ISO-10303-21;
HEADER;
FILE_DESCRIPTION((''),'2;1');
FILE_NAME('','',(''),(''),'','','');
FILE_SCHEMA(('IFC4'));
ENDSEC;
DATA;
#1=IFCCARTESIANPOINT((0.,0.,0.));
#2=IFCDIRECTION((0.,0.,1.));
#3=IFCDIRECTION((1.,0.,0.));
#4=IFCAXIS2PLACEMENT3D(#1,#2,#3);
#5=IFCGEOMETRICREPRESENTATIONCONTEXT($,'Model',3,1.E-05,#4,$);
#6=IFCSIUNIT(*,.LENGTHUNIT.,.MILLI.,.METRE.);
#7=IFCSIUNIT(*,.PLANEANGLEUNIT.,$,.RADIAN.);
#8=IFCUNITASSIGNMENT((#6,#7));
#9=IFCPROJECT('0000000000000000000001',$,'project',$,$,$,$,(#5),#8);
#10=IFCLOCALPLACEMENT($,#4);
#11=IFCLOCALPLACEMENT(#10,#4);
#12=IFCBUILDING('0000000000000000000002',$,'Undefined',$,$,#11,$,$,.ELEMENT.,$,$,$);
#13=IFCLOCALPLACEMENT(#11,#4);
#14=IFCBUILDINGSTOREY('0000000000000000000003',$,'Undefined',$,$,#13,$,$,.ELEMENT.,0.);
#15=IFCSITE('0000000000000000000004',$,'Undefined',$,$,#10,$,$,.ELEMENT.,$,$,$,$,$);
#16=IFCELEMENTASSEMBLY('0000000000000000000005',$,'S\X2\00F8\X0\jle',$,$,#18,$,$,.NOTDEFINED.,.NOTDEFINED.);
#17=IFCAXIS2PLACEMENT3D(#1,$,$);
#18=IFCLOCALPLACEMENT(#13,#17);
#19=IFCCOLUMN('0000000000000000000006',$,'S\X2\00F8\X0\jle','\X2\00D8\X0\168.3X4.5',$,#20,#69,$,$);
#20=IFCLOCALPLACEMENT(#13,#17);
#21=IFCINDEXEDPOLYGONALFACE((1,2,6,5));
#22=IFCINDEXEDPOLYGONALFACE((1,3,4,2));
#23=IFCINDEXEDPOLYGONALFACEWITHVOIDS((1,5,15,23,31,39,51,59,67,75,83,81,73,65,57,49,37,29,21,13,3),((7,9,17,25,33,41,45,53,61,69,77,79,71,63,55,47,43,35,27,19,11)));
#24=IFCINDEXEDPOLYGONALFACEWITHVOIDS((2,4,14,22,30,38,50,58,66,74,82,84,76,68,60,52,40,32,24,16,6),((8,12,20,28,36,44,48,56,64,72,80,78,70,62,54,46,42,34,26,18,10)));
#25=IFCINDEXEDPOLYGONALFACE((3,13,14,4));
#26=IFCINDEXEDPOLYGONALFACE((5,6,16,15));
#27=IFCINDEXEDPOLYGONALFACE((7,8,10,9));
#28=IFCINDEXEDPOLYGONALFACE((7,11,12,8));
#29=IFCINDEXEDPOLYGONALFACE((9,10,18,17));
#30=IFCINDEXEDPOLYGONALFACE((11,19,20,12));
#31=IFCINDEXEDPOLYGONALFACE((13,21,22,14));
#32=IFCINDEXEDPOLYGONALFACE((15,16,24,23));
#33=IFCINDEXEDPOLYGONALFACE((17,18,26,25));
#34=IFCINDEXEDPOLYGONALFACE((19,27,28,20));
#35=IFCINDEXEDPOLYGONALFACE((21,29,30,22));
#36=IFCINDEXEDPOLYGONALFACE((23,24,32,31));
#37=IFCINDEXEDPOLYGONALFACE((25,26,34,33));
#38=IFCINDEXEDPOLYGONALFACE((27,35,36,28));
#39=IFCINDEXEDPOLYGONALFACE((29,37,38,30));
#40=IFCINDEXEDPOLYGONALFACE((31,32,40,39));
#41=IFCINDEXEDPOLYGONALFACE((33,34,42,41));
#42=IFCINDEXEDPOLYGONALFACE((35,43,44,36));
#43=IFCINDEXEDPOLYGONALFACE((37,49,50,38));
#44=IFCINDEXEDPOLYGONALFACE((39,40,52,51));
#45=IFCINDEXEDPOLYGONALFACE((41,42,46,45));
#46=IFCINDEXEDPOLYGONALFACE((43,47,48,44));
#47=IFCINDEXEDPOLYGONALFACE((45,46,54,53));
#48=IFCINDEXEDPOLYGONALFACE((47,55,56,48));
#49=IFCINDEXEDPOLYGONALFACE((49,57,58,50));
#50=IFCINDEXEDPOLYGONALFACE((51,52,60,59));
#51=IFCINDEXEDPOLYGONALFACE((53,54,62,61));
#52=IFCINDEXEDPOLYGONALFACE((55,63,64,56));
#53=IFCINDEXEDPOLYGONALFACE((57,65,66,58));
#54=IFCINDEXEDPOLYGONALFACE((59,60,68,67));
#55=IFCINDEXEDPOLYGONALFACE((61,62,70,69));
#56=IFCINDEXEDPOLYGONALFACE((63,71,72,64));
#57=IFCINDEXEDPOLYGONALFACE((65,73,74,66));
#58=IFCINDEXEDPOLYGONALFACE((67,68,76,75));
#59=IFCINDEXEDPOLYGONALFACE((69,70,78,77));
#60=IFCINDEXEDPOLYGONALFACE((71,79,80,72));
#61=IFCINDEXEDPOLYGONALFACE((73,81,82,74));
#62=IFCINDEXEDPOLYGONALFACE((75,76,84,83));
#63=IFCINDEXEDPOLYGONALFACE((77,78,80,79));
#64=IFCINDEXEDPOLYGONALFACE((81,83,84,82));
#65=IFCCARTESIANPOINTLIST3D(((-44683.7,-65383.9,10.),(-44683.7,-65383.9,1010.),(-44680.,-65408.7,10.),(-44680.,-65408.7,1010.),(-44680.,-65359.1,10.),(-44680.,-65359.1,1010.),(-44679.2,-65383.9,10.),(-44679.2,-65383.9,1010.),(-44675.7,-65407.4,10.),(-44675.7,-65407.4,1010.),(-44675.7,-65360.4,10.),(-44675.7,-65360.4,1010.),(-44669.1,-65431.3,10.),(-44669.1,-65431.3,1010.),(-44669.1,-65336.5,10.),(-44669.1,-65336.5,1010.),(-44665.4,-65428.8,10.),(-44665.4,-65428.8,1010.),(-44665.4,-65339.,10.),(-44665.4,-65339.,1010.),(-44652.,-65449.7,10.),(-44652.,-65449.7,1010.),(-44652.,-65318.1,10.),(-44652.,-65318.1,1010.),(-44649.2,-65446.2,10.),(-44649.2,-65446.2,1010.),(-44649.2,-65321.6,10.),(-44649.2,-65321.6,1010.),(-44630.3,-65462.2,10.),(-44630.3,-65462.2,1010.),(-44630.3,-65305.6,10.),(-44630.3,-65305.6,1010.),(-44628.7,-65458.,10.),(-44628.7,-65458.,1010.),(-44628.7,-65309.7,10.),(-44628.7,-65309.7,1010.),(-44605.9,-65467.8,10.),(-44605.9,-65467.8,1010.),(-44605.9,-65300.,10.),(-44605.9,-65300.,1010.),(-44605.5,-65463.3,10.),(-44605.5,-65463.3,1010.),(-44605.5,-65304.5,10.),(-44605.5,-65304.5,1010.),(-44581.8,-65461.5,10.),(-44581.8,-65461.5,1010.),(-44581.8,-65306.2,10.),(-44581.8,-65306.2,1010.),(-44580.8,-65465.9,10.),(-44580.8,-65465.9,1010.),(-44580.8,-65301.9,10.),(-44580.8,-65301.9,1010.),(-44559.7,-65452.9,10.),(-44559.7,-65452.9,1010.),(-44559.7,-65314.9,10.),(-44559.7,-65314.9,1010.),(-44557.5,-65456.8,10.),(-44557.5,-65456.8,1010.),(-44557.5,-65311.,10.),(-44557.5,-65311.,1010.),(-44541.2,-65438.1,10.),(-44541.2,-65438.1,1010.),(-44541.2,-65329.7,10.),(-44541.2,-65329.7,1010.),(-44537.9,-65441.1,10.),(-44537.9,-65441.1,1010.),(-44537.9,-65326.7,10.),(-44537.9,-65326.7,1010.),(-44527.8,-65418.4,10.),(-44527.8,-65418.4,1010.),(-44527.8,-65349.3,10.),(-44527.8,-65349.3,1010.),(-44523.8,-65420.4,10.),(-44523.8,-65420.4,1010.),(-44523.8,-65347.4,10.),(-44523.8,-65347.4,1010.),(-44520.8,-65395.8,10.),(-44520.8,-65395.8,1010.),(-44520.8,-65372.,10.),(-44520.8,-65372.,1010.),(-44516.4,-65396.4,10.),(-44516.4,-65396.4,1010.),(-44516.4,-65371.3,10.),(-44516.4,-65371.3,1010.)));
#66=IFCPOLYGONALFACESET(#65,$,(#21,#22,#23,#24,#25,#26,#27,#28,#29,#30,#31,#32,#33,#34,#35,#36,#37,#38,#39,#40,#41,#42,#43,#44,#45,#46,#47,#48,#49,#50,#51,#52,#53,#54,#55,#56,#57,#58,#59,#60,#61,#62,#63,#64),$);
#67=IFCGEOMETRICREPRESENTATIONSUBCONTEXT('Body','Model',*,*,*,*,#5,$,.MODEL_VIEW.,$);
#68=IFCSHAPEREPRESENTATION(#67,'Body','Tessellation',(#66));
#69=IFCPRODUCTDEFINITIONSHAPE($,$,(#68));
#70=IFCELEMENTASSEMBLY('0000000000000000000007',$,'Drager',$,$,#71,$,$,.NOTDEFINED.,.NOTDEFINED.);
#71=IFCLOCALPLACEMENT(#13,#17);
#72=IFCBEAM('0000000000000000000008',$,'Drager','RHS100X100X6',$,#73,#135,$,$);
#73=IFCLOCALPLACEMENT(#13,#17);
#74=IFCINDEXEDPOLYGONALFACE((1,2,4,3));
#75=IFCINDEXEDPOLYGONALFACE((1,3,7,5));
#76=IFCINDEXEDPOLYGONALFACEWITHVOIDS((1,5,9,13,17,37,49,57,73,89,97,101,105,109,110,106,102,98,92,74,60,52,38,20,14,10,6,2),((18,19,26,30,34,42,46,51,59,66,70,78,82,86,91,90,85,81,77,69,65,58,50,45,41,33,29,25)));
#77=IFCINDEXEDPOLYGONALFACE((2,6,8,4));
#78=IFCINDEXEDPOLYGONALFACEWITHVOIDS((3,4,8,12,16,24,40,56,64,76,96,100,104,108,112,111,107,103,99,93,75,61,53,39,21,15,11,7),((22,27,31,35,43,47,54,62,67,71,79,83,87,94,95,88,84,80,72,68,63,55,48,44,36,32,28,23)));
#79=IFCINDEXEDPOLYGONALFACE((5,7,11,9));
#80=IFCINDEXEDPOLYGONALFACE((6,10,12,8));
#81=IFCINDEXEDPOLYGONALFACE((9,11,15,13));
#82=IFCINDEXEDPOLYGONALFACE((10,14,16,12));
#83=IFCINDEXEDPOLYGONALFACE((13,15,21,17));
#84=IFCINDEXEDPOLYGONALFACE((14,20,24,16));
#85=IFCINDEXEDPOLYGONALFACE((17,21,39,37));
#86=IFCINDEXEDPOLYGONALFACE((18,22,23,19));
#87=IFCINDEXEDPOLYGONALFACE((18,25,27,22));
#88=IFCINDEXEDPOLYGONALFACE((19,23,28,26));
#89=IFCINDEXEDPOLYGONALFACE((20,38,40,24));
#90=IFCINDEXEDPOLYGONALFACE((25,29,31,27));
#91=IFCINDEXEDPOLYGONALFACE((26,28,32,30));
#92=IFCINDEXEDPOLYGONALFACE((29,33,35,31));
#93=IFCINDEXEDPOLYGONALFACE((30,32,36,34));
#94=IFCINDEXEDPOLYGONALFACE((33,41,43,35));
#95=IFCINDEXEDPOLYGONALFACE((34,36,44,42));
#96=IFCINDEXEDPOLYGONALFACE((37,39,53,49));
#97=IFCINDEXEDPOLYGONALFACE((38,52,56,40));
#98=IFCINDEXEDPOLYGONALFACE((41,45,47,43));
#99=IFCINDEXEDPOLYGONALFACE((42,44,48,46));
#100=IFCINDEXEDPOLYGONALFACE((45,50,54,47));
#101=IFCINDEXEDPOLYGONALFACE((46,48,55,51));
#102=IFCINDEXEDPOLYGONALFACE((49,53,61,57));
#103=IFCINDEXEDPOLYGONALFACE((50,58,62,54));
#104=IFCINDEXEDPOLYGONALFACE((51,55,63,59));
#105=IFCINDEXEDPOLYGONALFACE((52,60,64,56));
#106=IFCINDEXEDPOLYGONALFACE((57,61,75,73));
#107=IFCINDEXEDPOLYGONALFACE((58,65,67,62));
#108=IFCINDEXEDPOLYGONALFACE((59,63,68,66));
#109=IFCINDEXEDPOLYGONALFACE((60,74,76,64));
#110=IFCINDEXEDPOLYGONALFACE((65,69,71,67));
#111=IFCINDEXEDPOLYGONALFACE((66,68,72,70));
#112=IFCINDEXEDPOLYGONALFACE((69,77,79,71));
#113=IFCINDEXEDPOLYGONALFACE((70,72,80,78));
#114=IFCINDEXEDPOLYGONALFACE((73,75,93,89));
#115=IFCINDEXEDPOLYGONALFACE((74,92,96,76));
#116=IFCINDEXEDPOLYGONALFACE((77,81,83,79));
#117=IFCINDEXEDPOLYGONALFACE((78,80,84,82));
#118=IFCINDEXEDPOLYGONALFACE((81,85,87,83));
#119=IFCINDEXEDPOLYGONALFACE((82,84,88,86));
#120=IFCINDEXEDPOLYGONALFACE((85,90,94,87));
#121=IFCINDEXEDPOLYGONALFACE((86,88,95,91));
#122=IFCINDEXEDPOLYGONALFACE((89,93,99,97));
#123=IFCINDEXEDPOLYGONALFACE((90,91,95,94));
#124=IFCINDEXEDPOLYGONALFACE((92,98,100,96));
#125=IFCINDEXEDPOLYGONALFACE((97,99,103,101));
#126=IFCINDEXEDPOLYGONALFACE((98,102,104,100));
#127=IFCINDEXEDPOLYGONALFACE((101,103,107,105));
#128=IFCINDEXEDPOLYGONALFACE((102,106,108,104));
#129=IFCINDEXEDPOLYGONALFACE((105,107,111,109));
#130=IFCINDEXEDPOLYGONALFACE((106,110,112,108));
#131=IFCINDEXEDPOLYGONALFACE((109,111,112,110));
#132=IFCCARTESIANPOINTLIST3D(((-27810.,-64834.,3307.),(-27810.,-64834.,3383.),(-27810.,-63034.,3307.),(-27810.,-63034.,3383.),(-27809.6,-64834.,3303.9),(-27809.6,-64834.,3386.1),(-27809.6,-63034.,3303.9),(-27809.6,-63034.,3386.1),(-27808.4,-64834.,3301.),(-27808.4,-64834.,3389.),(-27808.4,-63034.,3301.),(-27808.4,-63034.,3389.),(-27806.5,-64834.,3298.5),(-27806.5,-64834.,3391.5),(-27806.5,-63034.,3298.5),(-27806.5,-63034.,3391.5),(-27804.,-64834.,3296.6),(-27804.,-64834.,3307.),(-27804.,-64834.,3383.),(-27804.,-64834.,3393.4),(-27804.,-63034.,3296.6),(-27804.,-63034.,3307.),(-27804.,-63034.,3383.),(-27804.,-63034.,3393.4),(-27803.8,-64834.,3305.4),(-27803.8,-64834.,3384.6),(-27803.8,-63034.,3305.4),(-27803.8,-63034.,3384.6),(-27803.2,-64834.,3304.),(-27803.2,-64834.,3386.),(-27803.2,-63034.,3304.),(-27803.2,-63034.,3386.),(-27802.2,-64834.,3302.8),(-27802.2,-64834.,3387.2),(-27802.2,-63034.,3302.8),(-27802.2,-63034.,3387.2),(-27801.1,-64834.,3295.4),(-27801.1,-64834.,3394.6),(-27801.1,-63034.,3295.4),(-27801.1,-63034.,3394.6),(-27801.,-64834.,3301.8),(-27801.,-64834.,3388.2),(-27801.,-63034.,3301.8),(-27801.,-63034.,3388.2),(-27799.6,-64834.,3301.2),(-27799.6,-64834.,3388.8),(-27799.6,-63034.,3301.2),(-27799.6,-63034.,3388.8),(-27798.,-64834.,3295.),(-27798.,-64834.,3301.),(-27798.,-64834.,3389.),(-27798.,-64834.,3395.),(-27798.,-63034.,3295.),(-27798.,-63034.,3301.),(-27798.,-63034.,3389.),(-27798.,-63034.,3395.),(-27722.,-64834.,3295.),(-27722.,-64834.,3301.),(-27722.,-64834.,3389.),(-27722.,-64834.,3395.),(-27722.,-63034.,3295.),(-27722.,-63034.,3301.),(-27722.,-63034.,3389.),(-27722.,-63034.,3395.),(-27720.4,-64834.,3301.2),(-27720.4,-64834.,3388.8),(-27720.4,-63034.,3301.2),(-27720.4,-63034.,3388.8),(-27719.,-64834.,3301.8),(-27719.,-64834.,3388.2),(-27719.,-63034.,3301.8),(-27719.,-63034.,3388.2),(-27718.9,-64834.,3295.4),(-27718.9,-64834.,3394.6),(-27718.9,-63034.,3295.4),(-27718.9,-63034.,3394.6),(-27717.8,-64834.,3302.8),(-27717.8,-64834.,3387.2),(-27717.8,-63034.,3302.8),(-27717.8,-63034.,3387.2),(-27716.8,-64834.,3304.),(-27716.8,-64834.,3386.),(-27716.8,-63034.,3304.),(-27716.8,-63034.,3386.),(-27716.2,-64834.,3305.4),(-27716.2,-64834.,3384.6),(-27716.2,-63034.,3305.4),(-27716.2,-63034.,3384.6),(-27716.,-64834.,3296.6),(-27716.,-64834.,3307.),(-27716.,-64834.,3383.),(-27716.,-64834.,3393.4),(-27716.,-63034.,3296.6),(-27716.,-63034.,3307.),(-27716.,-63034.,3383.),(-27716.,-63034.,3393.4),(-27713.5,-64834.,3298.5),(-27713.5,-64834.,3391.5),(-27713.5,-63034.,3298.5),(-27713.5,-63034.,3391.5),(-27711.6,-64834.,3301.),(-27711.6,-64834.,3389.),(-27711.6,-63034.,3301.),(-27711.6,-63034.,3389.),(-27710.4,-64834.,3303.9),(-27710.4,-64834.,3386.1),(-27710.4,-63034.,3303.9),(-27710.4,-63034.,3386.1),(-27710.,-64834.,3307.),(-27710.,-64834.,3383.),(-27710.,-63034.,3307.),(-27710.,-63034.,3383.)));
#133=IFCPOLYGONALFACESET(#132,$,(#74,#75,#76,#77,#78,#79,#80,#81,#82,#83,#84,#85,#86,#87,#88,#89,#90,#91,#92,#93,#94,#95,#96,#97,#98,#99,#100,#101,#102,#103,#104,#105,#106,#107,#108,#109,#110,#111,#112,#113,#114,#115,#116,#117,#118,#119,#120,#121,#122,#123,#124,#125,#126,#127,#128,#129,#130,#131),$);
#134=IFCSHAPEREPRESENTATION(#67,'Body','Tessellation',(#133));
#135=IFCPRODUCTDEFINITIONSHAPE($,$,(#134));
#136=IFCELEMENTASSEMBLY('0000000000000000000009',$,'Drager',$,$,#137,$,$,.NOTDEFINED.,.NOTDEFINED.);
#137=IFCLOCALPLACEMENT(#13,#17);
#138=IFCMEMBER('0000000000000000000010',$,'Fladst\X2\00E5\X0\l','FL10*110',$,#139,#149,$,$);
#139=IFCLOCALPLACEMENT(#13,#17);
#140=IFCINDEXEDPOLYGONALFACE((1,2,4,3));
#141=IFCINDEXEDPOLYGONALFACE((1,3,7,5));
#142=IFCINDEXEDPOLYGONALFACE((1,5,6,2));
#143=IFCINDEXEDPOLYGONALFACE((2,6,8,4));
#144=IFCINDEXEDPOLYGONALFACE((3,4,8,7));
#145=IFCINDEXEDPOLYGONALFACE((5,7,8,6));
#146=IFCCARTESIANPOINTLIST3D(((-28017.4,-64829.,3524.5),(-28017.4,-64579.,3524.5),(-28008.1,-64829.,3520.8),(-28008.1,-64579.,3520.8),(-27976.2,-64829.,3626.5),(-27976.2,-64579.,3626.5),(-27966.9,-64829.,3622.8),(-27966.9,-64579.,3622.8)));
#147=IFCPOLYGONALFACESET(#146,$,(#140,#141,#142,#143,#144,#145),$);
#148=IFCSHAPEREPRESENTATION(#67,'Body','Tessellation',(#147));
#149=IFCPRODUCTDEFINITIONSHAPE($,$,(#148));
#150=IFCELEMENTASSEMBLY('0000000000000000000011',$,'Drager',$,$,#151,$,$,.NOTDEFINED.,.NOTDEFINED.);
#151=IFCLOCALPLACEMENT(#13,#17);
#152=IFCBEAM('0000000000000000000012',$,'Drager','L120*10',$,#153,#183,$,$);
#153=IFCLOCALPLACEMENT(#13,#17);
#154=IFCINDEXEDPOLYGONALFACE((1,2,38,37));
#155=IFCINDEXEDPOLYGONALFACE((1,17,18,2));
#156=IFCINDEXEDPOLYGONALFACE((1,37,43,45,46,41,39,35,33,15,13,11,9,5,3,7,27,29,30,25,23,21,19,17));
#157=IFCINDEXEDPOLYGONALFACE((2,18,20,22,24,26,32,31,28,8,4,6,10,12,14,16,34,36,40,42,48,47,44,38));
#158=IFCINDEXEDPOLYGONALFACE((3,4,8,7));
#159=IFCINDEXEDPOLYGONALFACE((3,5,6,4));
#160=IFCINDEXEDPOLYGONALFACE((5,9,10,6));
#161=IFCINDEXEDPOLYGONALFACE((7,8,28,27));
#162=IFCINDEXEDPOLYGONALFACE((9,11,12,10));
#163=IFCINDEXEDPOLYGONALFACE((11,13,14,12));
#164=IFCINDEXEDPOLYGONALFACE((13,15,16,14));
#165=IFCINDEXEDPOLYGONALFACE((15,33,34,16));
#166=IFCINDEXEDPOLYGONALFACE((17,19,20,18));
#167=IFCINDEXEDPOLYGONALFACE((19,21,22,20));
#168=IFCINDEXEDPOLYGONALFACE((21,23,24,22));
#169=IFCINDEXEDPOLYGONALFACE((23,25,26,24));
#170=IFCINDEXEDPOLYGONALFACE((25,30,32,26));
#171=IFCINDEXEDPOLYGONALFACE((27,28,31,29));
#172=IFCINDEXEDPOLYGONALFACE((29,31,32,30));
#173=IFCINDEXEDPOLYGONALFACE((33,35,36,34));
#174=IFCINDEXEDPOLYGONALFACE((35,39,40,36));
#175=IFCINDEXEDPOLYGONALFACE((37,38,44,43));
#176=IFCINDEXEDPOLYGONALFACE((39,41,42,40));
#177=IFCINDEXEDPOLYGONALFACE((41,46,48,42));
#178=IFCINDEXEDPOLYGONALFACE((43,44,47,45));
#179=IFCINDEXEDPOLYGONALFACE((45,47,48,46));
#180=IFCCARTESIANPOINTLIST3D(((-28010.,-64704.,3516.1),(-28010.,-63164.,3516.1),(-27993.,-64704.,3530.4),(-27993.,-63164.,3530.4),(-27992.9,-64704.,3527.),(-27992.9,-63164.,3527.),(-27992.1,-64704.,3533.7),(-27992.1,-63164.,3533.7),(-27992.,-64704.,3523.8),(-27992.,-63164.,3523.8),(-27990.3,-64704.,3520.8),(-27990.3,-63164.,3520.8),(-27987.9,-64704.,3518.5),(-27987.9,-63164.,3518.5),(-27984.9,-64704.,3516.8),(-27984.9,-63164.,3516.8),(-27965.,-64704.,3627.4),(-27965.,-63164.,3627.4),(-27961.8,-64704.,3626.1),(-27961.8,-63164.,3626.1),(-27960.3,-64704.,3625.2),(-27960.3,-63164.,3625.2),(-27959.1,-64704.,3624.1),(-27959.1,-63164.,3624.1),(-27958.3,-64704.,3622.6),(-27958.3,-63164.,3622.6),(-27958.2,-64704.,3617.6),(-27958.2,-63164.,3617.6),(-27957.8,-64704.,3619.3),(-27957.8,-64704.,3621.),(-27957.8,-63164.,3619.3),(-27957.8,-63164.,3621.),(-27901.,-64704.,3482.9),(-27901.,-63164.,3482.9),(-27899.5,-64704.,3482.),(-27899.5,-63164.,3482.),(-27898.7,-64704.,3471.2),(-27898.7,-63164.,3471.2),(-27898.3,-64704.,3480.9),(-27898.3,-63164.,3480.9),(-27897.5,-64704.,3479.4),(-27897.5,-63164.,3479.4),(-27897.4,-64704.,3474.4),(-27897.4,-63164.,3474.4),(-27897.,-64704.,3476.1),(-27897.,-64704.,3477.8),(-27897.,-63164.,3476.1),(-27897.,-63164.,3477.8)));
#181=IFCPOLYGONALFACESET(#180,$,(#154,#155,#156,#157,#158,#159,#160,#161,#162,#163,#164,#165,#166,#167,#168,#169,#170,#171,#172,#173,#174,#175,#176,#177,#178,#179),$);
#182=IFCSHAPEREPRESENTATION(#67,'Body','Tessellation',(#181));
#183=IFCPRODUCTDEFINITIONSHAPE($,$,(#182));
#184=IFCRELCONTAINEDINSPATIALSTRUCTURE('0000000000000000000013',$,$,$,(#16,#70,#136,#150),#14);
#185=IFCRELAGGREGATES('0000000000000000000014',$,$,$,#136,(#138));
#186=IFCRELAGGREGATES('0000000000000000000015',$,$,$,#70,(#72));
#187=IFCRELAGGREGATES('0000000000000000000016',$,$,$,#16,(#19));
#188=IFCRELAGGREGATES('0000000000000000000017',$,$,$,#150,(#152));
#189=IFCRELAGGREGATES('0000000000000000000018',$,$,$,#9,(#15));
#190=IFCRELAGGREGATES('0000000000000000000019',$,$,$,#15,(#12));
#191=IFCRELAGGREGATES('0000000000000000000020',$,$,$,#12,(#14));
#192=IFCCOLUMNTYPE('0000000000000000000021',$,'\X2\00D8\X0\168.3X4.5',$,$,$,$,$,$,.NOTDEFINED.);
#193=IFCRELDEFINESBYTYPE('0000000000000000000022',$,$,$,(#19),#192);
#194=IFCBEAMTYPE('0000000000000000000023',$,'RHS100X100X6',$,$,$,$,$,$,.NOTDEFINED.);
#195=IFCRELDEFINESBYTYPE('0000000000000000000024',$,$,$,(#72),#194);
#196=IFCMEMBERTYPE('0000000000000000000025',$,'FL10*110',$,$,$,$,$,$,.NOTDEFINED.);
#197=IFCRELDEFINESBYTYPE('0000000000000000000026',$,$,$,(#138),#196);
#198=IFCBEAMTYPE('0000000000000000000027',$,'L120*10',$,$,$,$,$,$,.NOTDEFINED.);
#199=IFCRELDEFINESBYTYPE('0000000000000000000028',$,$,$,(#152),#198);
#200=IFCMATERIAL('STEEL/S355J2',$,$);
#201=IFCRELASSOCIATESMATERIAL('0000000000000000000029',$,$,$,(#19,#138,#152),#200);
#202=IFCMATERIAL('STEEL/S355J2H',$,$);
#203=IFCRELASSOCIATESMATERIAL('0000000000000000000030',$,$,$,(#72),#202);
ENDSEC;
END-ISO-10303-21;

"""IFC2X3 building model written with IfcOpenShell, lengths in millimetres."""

from ifc_helpers import new_model, si_unit, frame, origin_with_axes, origin_2d_with_axis, place, context, subcontext, project, spatial, rectangle, hollow_rectangle, hollow_circle, l_section, extrude, clip, halfspace, material, type_object, element, aggregate, save


model = new_model("IFC2X3")

# Units and contexts
model_context = context("Model", 3, precision=1e-05, world=origin_with_axes())
body_context = subcontext(model_context, "Body", "Model", "MODEL_VIEW")
ifc_project = project(units=[si_unit("LENGTHUNIT", "METRE", prefix="MILLI"), si_unit("PLANEANGLEUNIT", "RADIAN")], contexts=[model_context])

# Site, building, storey
site_placement = place(None, origin_with_axes())
site = spatial("IfcSite", under=ifc_project, at=site_placement, Name="Undefined", CompositionType="ELEMENT")
building_placement = place(site_placement, origin_with_axes())
building = spatial("IfcBuilding", under=site, at=building_placement, Name="Undefined", CompositionType="ELEMENT")
storey_placement = place(building_placement, origin_with_axes())
storey = spatial("IfcBuildingStorey", under=building, at=storey_placement, Name="Undefined", CompositionType="ELEMENT", Elevation=0.0)

# Element assembly, column
assembly_1_placement = place(storey_placement, origin_with_axes())
assembly_1 = element("IfcElementAssembly", 1, at=assembly_1_placement, inside=storey, Name="Søjle", AssemblyPlace="NOTDEFINED", PredefinedType="NOTDEFINED")
ifc_material_1 = material(Name="STEEL/S355J2")
column_type = type_object("IfcColumnType", Name="Ø168.3X4.5", PredefinedType="NOTDEFINED")
column_placement = place(assembly_1_placement, frame((-44599.6, -65383.9, 0.0), z_axis=(0.0, 0.0, 1.0), x_axis=(0.0, 1.0, 0.0)))
column = element("IfcColumn", 2, at=column_placement, type_object=column_type, material=ifc_material_1, Name="Søjle", Description="Ø168.3X4.5", context=body_context, shape_type="Clipping", body=[
    clip(clip(extrude(hollow_circle(Radius=84.2, WallThickness=4.5, at=origin_2d_with_axis()), frame((0.0, 0.0, 1010.0), z_axis=(0.0, 0.0, -1.0), x_axis=(0.0, 1.0, 0.0)), (0.0, 0.0, 1.0), 1010.0), halfspace(frame((-84.1, 0.0, 1010.0), z_axis=(0.0, 0.0, -1.0), x_axis=(0.0, -1.0, 0.0)), True)), halfspace(frame((-84.1, 0.0, 10.0), z_axis=(0.0, 0.0, 1.0), x_axis=(0.0, 1.0, 0.0)), True)),
])

# Element assembly, beam
assembly_2_placement = place(storey_placement, origin_with_axes())
assembly_2 = element("IfcElementAssembly", 3, at=assembly_2_placement, inside=storey, Name="Drager", AssemblyPlace="NOTDEFINED", PredefinedType="NOTDEFINED")
ifc_material_2 = material(Name="STEEL/S355J2H")
beam_type_1 = type_object("IfcBeamType", Name="RHS100X100X6", PredefinedType="NOTDEFINED")
beam_1_placement = place(assembly_2_placement, frame((-27760.0, -63034.0, 3345.0), z_axis=(0.0, 0.0, 1.0), x_axis=(0.0, -1.0, 0.0)))
beam_1 = element("IfcBeam", 4, at=beam_1_placement, type_object=beam_type_1, material=ifc_material_2, Name="Drager", Description="RHS100X100X6", context=body_context, shape_type="SweptSolid", body=[
    extrude(hollow_rectangle(XDim=100.0, YDim=100.0, WallThickness=6.0, InnerFilletRadius=6.0, OuterFilletRadius=12.0, at=origin_2d_with_axis()), frame((1800.0, 0.0, 0.0), z_axis=(-1.0, 0.0, 0.0), x_axis=(0.0, -1.0, 0.0)), (0.0, 0.0, 1.0), 1800.0),
])

# Element assembly, member
assembly_3_placement = place(storey_placement, origin_with_axes())
assembly_3 = element("IfcElementAssembly", 5, at=assembly_3_placement, inside=storey, Name="Drager", AssemblyPlace="NOTDEFINED", PredefinedType="NOTDEFINED")
member_type = type_object("IfcMemberType", Name="FL10*110", PredefinedType="NOTDEFINED")
member_placement = place(assembly_3_placement, frame((-28012.8, -64704.0, 3522.6), z_axis=(0.0, -1.0, 0.0), x_axis=(0.374605, 0.0, 0.927184)))
member = element("IfcMember", 6, at=member_placement, type_object=member_type, material=ifc_material_1, Name="Fladstål", Description="FL10*110", context=body_context, shape_type="SweptSolid", body=[
    extrude(rectangle(XDim=10.0, YDim=250.0, at=origin_2d_with_axis()), frame((110.0, 0.0, 0.0), z_axis=(-1.0, 0.0, 0.0), x_axis=(0.0, -1.0, 0.0)), (0.0, 0.0, 1.0), 110.0),
])
aggregate(assembly_3, [member])

# Element assembly, beam
assembly_4_placement = place(storey_placement, origin_with_axes())
assembly_4 = element("IfcElementAssembly", 7, at=assembly_4_placement, inside=storey, Name="Drager", AssemblyPlace="NOTDEFINED", PredefinedType="NOTDEFINED")
beam_type_2 = type_object("IfcBeamType", Name="L120*10", PredefinedType="NOTDEFINED")
beam_2_placement = place(assembly_4_placement, frame((-27931.9, -63164.0, 3549.3), z_axis=(0.927184, 0.0, -0.374607), x_axis=(0.0, -1.0, 0.0)))
beam_2 = element("IfcBeam", 8, at=beam_2_placement, type_object=beam_type_2, material=ifc_material_1, Name="Drager", Description="L120*10", context=body_context, shape_type="SweptSolid", body=[
    extrude(l_section(Depth=120.0, Width=120.0, Thickness=10.0, FilletRadius=13.0, EdgeRadius=6.5, at=origin_2d_with_axis()), frame((1540.0, 0.0, 0.0), z_axis=(-1.0, 0.0, 0.0), x_axis=(0.0, -1.0, 0.0)), (0.0, 0.0, 1.0), 1540.0),
])

aggregate(assembly_2, [beam_1])

aggregate(assembly_1, [column])
aggregate(assembly_4, [beam_2])

save(model, "model.ifc")
